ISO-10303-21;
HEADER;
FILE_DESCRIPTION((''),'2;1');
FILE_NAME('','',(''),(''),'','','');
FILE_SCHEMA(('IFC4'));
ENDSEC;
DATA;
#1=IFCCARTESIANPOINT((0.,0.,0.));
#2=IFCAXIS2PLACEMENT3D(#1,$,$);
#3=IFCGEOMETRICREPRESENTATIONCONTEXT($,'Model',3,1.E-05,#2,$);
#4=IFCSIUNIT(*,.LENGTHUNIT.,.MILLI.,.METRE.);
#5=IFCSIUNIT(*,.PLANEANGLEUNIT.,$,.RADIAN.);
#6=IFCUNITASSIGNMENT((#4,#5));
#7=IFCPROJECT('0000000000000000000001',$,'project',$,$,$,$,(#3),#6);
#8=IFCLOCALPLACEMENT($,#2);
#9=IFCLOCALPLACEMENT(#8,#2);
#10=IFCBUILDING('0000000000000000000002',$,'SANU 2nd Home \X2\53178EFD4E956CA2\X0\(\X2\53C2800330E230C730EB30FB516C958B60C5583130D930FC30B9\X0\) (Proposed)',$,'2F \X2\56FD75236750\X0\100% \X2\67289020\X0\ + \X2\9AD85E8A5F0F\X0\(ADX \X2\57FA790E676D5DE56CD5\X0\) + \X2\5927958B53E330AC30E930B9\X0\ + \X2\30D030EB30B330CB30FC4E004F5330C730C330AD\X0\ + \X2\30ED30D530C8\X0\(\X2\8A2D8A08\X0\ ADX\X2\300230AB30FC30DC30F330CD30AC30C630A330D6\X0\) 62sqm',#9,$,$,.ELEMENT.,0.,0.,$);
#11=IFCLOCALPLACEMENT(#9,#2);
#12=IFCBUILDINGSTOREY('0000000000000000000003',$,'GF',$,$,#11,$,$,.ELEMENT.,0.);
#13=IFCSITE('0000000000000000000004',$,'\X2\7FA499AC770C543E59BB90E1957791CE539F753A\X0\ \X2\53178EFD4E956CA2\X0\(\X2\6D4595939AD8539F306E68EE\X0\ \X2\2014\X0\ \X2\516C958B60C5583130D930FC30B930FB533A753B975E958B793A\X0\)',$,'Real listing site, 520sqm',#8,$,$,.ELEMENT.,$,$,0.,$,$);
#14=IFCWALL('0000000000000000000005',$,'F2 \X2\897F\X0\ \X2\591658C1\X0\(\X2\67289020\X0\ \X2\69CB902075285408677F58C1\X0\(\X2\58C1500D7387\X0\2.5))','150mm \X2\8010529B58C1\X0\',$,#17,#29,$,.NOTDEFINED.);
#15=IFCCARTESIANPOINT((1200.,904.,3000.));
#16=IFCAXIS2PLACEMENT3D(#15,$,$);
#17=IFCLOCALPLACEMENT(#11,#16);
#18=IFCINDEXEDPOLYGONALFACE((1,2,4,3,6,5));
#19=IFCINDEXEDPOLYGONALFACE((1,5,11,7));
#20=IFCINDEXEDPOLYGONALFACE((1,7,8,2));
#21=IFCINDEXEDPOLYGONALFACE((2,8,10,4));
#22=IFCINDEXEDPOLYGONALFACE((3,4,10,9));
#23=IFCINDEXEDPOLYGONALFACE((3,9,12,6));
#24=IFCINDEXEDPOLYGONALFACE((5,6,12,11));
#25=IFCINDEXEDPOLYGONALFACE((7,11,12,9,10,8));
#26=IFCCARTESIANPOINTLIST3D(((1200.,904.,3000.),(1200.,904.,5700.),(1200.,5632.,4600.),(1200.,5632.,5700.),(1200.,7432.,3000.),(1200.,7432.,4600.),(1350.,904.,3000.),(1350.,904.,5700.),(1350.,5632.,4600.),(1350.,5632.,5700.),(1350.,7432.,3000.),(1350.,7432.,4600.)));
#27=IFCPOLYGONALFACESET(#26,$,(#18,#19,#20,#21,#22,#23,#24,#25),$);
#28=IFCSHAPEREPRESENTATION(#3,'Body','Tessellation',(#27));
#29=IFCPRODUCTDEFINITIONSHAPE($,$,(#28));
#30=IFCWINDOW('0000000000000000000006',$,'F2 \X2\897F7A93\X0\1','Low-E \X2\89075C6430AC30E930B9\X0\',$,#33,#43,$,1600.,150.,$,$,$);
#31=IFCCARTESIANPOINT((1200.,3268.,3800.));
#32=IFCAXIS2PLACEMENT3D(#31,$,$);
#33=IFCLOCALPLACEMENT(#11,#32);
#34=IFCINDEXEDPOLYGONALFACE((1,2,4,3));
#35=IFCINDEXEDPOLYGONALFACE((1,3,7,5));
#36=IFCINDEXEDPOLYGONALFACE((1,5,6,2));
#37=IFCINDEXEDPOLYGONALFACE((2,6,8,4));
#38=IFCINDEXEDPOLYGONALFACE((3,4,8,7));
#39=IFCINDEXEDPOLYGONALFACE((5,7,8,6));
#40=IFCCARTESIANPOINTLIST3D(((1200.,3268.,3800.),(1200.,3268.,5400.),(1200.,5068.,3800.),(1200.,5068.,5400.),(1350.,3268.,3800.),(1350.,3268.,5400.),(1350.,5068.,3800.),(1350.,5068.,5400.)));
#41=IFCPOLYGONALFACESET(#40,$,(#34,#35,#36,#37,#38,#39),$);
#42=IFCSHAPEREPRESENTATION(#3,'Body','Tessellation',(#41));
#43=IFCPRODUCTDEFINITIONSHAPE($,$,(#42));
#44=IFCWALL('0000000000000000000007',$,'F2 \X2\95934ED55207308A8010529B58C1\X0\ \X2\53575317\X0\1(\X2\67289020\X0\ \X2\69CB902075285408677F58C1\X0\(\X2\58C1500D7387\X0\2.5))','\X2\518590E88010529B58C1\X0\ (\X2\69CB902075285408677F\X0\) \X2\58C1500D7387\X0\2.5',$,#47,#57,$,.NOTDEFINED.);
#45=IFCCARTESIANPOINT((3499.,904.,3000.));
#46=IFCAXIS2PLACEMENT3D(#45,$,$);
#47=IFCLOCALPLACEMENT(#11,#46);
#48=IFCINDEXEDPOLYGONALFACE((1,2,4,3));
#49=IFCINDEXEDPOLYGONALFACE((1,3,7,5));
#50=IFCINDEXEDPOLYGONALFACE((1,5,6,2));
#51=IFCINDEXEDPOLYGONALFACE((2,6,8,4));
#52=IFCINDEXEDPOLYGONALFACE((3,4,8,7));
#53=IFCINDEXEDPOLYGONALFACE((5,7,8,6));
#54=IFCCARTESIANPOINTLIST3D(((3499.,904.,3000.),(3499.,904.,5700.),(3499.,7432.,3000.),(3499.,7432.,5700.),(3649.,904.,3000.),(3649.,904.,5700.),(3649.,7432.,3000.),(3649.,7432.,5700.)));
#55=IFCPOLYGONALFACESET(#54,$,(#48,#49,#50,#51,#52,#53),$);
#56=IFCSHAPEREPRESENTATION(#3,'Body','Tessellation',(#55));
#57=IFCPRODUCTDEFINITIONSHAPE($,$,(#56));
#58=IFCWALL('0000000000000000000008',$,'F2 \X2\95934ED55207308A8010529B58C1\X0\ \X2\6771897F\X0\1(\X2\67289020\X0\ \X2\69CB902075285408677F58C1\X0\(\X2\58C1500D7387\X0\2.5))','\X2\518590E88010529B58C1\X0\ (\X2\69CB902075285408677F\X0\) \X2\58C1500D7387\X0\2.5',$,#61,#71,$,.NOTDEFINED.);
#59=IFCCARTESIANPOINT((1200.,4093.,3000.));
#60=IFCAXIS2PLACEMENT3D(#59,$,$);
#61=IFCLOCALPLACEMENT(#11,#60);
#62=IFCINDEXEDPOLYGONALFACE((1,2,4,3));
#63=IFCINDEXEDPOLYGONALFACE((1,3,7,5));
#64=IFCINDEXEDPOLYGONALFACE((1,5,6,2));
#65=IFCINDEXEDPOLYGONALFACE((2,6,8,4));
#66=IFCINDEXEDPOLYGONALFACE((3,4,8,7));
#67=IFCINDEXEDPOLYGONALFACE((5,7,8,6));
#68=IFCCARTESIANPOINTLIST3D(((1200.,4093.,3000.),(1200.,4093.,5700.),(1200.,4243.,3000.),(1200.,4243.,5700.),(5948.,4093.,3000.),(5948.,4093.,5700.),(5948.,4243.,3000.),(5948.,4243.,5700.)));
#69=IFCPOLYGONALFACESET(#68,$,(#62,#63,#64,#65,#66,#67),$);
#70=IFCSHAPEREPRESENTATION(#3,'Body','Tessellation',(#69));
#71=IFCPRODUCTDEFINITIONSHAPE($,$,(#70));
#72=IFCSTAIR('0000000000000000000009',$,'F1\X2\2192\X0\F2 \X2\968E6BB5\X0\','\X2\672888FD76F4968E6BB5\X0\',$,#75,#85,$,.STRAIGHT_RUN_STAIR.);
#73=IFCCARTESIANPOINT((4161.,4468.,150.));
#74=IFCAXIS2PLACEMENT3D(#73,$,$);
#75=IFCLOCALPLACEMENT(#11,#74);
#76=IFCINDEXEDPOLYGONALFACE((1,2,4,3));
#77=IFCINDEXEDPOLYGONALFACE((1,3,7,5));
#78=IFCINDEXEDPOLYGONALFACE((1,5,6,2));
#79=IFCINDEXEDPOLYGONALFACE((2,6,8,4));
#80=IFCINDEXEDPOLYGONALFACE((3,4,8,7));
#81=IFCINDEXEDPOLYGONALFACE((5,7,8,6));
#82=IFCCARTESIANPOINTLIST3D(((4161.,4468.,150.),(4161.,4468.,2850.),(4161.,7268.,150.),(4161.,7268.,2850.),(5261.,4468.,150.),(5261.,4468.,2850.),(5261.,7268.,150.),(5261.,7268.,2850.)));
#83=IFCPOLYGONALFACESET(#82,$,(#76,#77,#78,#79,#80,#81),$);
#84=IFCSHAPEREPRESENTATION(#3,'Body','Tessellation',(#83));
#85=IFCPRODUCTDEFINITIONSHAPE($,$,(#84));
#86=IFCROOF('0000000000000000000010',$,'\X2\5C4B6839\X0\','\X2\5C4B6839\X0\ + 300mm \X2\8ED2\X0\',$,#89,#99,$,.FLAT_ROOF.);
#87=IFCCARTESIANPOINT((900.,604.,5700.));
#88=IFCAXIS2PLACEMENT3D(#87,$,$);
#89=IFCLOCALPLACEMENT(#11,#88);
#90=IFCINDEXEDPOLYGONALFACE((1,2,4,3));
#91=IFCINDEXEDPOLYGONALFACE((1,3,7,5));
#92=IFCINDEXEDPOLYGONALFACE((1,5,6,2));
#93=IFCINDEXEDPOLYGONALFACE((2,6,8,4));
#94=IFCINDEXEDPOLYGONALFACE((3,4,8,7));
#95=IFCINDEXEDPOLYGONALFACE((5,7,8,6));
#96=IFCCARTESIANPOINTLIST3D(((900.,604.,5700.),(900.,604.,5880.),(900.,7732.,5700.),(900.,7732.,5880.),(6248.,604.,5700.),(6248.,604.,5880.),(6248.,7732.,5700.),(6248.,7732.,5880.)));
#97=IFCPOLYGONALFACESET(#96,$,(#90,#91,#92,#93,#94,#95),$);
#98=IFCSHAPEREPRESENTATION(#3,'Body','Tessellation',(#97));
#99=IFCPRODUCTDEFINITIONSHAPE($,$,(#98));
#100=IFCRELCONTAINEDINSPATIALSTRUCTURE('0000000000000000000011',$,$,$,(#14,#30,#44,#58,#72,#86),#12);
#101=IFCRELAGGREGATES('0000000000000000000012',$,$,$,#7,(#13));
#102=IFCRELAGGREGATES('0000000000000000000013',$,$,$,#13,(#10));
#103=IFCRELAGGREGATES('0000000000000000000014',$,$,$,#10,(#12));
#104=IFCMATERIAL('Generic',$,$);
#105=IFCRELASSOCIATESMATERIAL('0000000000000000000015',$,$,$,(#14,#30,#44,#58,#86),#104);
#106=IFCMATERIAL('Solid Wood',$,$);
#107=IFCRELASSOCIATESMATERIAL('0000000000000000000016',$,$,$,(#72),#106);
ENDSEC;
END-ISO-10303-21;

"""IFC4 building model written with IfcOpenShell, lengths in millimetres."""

from ifc_helpers import new_model, si_unit, frame, frame_2d, origin, place, context, project, spatial, rectangle, extrude, material, element, fill, save


model = new_model("IFC4")

# Units and contexts
model_context = context("Model", 3, precision=1e-05, world=origin())
ifc_project = project(units=[si_unit("LENGTHUNIT", "METRE", prefix="MILLI"), si_unit("PLANEANGLEUNIT", "RADIAN")], contexts=[model_context])

# Site, building, storey
site_placement = place(None, origin())
site = spatial("IfcSite", under=ifc_project, at=site_placement, Name="群馬県吾妻郡長野原町 北軽井沢(浅間高原の森 — 公開情報ベース・区画非開示)", ObjectType="Real listing site, 520sqm", CompositionType="ELEMENT", RefElevation=0.0)
building_placement = place(site_placement, origin())
building = spatial("IfcBuilding", under=site, at=building_placement, Name="SANU 2nd Home 北軽井沢(参考モデル・公開情報ベース) (Proposed)", ObjectType="2F 国産材100% 木造 + 高床式(ADX 基礎杭工法) + 大開口ガラス + バルコニー一体デッキ + ロフト(設計 ADX。カーボンネガティブ) 62sqm", CompositionType="ELEMENT", ElevationOfRefHeight=0.0, ElevationOfTerrain=0.0)
storey_placement = place(building_placement, origin())
storey = spatial("IfcBuildingStorey", under=building, at=storey_placement, Name="GF", CompositionType="ELEMENT", Elevation=0.0)

# Shared definitions
ifc_material_1 = material(Name="Generic")

# Shared definitions
ifc_material_2 = material(Name="Solid Wood")

# Wall, opening, window
wall_1_placement = place(storey_placement, frame((1200.0, 904.0, 3000.0)))
wall_1 = element("IfcWall", 1, at=wall_1_placement, inside=storey, material=ifc_material_1, Name="F2 西 外壁(木造 構造用合板壁(壁倍率2.5))", Description="150mm 耐力壁", PredefinedType="NOTDEFINED", context=model_context, shape_type="SweptSolid", body=[
    extrude(rectangle(XDim=150.0, YDim=6528.0, at=frame_2d((75.0, 3264.0))), frame((1200.0, 904.0, 3000.0)), (0.0, 0.0, 1.0), 2700.0),
])
opening_1_placement = place(storey_placement, frame((1200.0, 3268.0, 3800.0)))
opening_1 = element("IfcOpeningElement", 2, at=opening_1_placement, cuts=wall_1, PredefinedType="NOTDEFINED", context=model_context, shape_type="SweptSolid", body=[
    extrude(rectangle(XDim=150.0, YDim=1800.0, at=frame_2d((75.0, 900.0))), frame((1200.0, 3268.0, 3800.0)), (0.0, 0.0, 1.0), 1600.0),
])
window_1_placement = place(storey_placement, frame((1200.0, 3268.0, 3800.0)))
window_1 = element("IfcWindow", 3, at=window_1_placement, inside=storey, material=ifc_material_1, Name="F2 西窓1", Description="Low-E 複層ガラス", OverallHeight=1600.0, OverallWidth=150.0, context=model_context, shape_type="SweptSolid", body=[
    extrude(rectangle(XDim=150.0, YDim=1800.0, at=frame_2d((75.0, 900.0))), frame((1200.0, 3268.0, 3800.0)), (0.0, 0.0, 1.0), 1600.0),
])
fill(opening_1, window_1)

# Walls
wall_2_placement = place(storey_placement, frame((3499.0, 904.0, 3000.0)))
element("IfcWall", 4, at=wall_2_placement, inside=storey, material=ifc_material_1, Name="F2 間仕切り耐力壁 南北1(木造 構造用合板壁(壁倍率2.5))", Description="内部耐力壁 (構造用合板) 壁倍率2.5", PredefinedType="NOTDEFINED", context=model_context, shape_type="SweptSolid", body=[
    extrude(rectangle(XDim=150.0, YDim=6528.0, at=frame_2d((75.0, 3264.0))), frame((3499.0, 904.0, 3000.0)), (0.0, 0.0, 1.0), 2700.0),
])
wall_3_placement = place(storey_placement, frame((1200.0, 4093.0, 3000.0)))
element("IfcWall", 5, at=wall_3_placement, inside=storey, material=ifc_material_1, Name="F2 間仕切り耐力壁 東西1(木造 構造用合板壁(壁倍率2.5))", Description="内部耐力壁 (構造用合板) 壁倍率2.5", PredefinedType="NOTDEFINED", context=model_context, shape_type="SweptSolid", body=[
    extrude(rectangle(XDim=4748.0, YDim=150.0, at=frame_2d((2374.0, 75.0))), frame((1200.0, 4093.0, 3000.0)), (0.0, 0.0, 1.0), 2700.0),
])

# Stair
stair_placement = place(storey_placement, frame((4161.0, 4468.0, 150.0)))
element("IfcStair", 6, at=stair_placement, inside=storey, material=ifc_material_2, Name="F1→F2 階段", Description="木製直階段", PredefinedType="STRAIGHT_RUN_STAIR", context=model_context, shape_type="SweptSolid", body=[
    extrude(rectangle(XDim=1100.0, YDim=2800.0, at=frame_2d((550.0, 1400.0))), frame((4161.0, 4468.0, 150.0)), (0.0, 0.0, 1.0), 2700.0),
])

# Roof
roof_placement = place(storey_placement, frame((900.0, 604.0, 5700.0)))
element("IfcRoof", 7, at=roof_placement, inside=storey, material=ifc_material_1, Name="屋根", Description="屋根 + 300mm 軒", PredefinedType="FLAT_ROOF", context=model_context, shape_type="SweptSolid", body=[
    extrude(rectangle(XDim=5348.0, YDim=7128.0, at=frame_2d((2674.0, 3564.0))), frame((900.0, 604.0, 5700.0)), (0.0, 0.0, 1.0), 180.0),
])

save(model, "model.ifc")
